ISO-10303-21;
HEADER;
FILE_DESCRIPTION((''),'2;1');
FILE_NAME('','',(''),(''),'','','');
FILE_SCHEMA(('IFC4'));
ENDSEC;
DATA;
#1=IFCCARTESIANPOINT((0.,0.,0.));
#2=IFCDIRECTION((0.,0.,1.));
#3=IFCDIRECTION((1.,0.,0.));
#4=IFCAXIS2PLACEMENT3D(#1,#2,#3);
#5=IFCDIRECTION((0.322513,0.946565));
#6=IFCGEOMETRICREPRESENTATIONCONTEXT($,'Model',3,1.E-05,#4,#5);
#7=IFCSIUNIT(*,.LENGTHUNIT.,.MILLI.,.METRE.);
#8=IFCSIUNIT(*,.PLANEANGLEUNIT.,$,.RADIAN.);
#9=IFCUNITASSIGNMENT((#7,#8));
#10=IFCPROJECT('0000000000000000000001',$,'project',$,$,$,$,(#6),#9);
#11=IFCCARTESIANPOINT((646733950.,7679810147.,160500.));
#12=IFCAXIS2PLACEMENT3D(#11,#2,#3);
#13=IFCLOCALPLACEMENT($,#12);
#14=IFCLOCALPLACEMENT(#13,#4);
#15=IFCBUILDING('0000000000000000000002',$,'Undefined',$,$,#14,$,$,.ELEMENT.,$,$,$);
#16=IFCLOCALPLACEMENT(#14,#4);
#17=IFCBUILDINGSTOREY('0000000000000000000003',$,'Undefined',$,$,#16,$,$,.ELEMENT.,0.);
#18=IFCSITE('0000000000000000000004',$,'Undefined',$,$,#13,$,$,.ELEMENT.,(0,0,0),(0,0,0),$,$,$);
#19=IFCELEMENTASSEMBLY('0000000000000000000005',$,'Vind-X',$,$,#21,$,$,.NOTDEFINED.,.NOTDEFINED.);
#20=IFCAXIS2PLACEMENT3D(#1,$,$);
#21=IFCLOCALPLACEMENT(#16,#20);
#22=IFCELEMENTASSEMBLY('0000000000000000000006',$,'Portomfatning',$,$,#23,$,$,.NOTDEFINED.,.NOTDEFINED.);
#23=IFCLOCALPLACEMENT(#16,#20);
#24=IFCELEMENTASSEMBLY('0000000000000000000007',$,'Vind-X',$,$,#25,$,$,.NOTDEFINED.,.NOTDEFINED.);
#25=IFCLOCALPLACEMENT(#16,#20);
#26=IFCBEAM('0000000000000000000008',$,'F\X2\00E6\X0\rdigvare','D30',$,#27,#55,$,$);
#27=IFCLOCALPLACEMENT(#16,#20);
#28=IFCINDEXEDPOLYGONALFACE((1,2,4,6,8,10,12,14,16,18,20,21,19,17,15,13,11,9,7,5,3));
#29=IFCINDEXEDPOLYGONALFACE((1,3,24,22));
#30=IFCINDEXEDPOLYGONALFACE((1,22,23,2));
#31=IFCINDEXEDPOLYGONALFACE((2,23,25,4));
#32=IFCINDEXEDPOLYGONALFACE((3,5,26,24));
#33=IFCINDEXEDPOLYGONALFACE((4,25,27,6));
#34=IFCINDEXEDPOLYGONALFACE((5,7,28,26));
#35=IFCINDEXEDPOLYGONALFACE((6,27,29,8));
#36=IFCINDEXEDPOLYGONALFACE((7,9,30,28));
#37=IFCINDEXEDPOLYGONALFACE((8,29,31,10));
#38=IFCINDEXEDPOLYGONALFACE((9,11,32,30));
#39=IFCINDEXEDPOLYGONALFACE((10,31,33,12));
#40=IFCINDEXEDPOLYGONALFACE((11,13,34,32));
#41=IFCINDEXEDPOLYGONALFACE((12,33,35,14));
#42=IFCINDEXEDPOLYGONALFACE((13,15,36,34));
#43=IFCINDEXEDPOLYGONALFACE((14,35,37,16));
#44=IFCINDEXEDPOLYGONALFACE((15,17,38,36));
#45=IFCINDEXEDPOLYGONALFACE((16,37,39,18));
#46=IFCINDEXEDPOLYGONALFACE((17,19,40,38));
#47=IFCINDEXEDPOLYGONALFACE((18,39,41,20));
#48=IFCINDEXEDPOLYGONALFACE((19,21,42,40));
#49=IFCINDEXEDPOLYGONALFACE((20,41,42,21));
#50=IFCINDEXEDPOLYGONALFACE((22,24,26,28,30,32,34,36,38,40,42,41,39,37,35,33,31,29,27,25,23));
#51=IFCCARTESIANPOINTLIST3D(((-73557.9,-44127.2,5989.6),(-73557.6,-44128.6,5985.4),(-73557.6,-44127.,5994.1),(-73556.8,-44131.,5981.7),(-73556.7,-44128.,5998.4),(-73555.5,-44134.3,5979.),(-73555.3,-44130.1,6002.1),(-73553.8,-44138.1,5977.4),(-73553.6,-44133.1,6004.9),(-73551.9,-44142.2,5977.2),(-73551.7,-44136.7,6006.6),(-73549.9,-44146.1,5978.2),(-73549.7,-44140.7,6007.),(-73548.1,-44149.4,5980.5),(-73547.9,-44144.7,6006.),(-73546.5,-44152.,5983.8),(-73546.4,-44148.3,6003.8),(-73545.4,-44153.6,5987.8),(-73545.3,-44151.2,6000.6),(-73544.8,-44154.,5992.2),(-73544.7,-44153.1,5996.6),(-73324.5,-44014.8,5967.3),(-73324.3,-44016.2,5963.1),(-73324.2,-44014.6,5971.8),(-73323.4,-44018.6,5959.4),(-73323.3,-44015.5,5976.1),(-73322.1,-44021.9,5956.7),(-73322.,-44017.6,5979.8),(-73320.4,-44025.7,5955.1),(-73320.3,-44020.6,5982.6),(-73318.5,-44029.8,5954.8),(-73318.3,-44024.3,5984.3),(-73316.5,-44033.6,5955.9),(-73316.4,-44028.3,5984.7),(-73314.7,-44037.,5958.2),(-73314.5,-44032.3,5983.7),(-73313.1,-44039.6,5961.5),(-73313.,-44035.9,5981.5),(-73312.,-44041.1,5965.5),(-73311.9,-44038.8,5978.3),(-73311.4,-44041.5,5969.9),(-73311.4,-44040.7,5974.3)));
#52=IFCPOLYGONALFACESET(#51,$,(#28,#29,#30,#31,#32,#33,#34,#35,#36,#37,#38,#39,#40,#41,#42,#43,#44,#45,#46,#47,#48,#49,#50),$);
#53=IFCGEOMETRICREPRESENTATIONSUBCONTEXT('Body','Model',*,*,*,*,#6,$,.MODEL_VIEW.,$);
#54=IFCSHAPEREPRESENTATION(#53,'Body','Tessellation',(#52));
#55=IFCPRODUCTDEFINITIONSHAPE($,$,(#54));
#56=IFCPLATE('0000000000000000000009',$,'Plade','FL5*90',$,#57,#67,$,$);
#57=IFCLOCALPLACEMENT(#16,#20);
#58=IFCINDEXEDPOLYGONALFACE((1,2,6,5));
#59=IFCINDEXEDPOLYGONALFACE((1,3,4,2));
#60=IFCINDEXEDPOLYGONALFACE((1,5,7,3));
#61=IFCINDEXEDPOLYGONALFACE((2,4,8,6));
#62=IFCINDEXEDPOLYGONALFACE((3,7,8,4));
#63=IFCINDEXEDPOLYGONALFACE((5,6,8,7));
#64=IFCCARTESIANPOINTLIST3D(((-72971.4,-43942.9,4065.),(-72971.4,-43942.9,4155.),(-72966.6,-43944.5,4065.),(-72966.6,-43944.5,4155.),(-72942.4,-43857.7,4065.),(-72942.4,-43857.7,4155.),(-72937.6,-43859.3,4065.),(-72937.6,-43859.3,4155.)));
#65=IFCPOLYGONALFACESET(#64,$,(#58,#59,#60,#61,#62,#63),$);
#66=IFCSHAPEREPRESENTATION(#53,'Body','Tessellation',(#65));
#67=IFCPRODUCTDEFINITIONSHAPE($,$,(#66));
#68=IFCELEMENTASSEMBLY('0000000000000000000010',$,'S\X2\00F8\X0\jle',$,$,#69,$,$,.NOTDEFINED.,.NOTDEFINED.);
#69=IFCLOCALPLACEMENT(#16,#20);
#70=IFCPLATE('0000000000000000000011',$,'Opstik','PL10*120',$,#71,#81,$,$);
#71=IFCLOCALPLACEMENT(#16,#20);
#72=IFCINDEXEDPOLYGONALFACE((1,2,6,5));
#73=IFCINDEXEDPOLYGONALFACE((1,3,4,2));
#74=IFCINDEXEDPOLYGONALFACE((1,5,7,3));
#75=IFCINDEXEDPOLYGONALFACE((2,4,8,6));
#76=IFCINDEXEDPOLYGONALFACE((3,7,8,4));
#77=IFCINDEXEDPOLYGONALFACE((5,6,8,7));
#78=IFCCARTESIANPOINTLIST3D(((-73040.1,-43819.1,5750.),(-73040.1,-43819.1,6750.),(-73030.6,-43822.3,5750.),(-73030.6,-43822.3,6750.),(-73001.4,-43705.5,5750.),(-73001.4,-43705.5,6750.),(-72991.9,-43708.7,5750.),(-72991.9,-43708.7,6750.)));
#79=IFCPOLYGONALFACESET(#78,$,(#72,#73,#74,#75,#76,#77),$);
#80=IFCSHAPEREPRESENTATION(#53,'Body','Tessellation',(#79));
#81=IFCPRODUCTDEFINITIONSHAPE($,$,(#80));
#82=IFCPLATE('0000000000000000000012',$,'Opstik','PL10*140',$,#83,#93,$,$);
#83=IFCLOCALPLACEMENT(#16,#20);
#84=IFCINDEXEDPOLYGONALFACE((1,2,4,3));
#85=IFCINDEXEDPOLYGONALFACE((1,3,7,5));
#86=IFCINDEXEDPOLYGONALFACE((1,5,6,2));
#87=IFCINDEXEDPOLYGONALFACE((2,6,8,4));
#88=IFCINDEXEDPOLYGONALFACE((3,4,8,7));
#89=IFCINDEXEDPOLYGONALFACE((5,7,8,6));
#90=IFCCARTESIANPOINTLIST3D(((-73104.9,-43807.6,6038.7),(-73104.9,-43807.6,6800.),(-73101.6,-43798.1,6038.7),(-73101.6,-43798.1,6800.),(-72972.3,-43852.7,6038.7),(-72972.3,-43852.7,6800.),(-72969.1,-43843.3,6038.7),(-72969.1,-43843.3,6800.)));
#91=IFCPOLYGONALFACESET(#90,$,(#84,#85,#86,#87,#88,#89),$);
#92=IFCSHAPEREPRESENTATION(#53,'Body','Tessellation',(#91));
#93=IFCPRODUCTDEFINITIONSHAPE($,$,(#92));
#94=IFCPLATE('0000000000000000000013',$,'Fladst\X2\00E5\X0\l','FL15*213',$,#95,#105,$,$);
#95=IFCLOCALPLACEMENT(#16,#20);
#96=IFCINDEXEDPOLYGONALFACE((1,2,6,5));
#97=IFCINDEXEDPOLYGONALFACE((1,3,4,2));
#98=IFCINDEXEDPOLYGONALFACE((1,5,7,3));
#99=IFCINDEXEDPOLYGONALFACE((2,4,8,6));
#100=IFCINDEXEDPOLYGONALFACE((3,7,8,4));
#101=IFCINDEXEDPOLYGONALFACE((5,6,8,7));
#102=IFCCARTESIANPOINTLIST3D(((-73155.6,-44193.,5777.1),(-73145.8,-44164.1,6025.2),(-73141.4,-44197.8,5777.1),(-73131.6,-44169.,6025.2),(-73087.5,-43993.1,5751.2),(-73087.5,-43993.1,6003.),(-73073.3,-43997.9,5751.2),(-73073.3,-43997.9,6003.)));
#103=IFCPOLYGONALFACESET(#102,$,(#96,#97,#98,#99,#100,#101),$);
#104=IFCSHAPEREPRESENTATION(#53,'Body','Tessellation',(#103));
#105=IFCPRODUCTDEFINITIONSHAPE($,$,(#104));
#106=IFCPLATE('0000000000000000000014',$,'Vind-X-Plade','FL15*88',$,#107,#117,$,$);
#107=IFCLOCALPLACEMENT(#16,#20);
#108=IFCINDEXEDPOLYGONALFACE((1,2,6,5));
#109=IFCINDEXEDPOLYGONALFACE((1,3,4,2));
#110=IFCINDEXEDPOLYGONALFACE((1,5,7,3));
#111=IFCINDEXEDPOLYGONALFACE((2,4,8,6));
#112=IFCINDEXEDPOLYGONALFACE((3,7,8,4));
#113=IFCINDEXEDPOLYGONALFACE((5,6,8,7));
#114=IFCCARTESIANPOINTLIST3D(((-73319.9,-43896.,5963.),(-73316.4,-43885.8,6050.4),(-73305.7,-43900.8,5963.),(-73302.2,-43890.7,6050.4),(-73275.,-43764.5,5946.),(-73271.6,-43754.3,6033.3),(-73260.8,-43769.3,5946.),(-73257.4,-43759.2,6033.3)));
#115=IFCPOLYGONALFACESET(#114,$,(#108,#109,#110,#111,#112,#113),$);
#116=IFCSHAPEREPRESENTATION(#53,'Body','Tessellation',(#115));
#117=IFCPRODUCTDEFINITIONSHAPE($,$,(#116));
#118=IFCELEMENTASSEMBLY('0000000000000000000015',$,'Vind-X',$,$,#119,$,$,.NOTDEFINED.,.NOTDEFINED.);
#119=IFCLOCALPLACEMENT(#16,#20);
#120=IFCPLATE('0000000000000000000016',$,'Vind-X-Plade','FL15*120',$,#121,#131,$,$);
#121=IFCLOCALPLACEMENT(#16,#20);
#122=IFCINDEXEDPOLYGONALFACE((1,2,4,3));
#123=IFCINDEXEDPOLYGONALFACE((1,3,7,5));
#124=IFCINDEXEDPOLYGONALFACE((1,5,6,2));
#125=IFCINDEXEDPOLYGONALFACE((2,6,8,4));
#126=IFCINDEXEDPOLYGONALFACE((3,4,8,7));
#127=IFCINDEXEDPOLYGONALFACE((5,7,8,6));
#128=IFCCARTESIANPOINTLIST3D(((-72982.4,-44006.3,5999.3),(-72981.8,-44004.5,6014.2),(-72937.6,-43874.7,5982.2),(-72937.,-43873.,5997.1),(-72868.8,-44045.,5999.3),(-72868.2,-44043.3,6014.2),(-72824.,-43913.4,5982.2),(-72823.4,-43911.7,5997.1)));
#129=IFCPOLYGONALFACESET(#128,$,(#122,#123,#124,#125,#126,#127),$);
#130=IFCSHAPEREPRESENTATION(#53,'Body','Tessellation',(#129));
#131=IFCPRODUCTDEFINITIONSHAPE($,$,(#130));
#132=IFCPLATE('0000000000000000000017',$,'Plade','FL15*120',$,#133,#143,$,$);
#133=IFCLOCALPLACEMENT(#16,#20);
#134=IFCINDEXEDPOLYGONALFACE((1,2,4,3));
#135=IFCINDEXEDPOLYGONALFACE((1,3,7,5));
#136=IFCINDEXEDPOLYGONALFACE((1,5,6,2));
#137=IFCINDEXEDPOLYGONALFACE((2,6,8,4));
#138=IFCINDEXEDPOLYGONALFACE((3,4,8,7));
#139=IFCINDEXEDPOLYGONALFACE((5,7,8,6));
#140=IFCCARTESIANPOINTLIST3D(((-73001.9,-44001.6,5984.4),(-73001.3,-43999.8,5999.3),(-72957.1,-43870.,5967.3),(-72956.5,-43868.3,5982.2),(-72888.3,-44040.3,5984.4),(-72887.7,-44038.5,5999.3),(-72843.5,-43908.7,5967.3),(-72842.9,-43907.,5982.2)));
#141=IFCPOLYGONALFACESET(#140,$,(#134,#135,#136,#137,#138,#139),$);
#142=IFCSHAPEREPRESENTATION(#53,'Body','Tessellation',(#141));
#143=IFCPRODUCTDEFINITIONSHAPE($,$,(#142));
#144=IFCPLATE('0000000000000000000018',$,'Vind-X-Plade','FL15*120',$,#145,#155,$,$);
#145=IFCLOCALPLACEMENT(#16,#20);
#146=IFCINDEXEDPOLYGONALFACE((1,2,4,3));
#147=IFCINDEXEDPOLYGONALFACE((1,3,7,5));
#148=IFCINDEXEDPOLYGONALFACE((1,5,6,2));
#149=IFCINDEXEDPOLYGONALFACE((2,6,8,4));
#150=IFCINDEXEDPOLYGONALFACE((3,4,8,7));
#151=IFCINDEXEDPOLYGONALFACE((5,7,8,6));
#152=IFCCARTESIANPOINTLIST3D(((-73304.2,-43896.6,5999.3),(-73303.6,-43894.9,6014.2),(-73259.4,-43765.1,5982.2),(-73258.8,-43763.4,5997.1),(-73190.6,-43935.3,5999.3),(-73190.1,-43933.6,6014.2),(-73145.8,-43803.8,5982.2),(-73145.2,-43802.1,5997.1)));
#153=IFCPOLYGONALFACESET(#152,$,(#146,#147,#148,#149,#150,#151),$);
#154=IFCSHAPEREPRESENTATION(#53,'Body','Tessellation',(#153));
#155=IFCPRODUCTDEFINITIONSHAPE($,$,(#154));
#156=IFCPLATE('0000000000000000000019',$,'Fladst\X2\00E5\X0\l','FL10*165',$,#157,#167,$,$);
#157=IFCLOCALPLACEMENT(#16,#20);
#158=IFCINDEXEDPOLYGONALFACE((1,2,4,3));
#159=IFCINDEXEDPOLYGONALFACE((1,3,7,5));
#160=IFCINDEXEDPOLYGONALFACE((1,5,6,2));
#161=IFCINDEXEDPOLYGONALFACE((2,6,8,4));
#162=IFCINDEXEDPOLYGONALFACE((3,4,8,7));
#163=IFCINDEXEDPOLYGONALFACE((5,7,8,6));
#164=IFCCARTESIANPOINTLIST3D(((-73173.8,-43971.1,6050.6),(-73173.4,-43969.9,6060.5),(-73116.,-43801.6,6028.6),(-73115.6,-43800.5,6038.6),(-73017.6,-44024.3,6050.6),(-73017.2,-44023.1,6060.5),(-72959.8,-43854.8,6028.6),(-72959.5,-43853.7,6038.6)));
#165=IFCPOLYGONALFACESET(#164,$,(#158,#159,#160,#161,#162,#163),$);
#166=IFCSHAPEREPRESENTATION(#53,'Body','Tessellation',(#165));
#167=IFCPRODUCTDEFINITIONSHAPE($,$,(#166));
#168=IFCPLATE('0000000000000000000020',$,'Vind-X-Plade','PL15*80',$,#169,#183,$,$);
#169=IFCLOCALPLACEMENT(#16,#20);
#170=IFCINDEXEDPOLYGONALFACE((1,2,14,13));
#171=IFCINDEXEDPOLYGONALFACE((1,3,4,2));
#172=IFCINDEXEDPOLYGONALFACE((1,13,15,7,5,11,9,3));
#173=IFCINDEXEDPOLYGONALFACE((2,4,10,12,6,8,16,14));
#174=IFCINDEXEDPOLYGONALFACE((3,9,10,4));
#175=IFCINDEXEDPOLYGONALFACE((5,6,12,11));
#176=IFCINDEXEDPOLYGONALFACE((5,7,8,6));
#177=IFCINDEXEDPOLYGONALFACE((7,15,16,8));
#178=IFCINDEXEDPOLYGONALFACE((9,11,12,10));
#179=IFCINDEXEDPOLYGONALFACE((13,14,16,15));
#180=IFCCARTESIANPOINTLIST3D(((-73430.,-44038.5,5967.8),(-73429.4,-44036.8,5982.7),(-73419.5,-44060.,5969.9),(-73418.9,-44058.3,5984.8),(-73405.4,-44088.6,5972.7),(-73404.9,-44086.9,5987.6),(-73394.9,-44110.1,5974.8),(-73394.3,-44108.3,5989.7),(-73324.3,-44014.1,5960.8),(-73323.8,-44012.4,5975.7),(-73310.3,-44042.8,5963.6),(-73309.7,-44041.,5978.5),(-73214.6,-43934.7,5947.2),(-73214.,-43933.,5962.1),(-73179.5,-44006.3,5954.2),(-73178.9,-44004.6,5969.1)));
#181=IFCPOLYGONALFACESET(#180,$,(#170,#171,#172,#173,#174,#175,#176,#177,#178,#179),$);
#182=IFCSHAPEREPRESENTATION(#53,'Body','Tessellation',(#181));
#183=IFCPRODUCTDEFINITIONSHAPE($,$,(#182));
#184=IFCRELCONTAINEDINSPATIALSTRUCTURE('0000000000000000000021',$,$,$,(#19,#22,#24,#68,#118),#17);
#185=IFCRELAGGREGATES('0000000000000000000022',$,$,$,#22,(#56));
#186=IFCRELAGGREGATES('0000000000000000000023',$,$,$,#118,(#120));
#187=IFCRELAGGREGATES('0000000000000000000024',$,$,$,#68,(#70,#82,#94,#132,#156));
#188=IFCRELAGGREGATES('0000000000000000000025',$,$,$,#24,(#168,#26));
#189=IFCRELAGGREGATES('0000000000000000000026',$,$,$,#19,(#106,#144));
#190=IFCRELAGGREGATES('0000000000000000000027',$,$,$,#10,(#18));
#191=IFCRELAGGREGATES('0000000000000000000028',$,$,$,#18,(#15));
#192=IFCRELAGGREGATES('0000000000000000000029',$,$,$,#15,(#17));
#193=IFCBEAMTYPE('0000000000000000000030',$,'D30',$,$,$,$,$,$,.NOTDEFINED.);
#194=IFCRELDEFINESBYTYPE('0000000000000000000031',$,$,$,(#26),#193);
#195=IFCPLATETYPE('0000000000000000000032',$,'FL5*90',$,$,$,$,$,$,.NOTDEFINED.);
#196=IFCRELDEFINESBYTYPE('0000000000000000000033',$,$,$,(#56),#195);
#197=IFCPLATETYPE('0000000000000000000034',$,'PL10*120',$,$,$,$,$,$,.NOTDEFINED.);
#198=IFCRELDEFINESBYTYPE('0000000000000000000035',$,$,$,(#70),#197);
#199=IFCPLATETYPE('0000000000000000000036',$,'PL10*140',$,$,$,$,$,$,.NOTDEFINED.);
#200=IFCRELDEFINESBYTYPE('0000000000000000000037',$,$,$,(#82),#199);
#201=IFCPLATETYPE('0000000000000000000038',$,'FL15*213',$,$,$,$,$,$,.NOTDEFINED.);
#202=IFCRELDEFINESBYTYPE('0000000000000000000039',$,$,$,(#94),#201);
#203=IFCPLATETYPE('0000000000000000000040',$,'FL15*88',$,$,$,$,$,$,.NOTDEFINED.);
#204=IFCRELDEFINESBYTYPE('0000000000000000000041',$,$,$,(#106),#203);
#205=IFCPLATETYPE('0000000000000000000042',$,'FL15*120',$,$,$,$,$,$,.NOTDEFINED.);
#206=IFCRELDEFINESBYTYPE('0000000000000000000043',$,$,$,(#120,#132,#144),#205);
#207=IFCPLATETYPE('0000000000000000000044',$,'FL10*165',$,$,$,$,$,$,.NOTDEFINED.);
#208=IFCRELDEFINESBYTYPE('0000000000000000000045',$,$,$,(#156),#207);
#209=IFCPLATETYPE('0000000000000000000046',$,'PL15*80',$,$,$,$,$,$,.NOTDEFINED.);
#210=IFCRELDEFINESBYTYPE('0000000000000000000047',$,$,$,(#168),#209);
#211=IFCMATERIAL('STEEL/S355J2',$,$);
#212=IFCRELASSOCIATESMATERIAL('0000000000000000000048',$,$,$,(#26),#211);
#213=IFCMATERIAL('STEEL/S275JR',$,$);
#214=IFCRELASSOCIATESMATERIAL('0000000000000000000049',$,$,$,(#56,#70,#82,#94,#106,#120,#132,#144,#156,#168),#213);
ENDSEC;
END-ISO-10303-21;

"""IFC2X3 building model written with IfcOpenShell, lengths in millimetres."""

from ifc_helpers import new_model, si_unit, direction, frame, origin_with_axes, origin_2d_with_axis, place, context, subcontext, project, spatial, polyline, circle, outline, extrude, boolean, material, type_object, element, aggregate, save


model = new_model("IFC2X3")

# Units and contexts
model_context = context("Model", 3, precision=1e-05, world=origin_with_axes(), true_north=direction((0.322513, 0.946565)))
body_context = subcontext(model_context, "Body", "Model", "MODEL_VIEW")
ifc_project = project(units=[si_unit("LENGTHUNIT", "METRE", prefix="MILLI"), si_unit("PLANEANGLEUNIT", "RADIAN")], contexts=[model_context])

# Site, building, storey
site_placement = place(None, frame((646733950.0, 7679810147.0, 160500.0), z_axis=(0.0, 0.0, 1.0), x_axis=(1.0, 0.0, 0.0)))
site = spatial("IfcSite", under=ifc_project, at=site_placement, Name="Undefined", CompositionType="ELEMENT", RefLatitude=(0, 0, 0), RefLongitude=(0, 0, 0))
building_placement = place(site_placement, origin_with_axes())
building = spatial("IfcBuilding", under=site, at=building_placement, Name="Undefined", CompositionType="ELEMENT")
storey_placement = place(building_placement, origin_with_axes())
storey = spatial("IfcBuildingStorey", under=building, at=storey_placement, Name="Undefined", CompositionType="ELEMENT", Elevation=0.0)

# Element assemblies
assembly_1_placement = place(storey_placement, origin_with_axes())
assembly_1 = element("IfcElementAssembly", 1, at=assembly_1_placement, inside=storey, Name="Vind-X", AssemblyPlace="NOTDEFINED", PredefinedType="NOTDEFINED")
assembly_2_placement = place(storey_placement, origin_with_axes())
assembly_2 = element("IfcElementAssembly", 2, at=assembly_2_placement, inside=storey, Name="Portomfatning", AssemblyPlace="NOTDEFINED", PredefinedType="NOTDEFINED")

# Element assembly, beam
assembly_3_placement = place(storey_placement, origin_with_axes())
assembly_3 = element("IfcElementAssembly", 3, at=assembly_3_placement, inside=storey, Name="Vind-X", AssemblyPlace="NOTDEFINED", PredefinedType="NOTDEFINED")
ifc_material_1 = material(Name="STEEL/S355J2")
beam_type_1 = type_object("IfcBeamType", Name="D30", PredefinedType="NOTDEFINED")
beam_1_placement = place(assembly_3_placement, frame((-73317.9, -44028.0, 5969.7), z_axis=(-0.439079, 0.89427, -0.086548), x_axis=(-0.897588, -0.432405, 0.0858)))
beam_1 = element("IfcBeam", 4, at=beam_1_placement, type_object=beam_type_1, material=ifc_material_1, Name="Færdigvare", Description="D30", context=body_context, shape_type="SweptSolid", body=[
    extrude(circle(Radius=15.0, at=origin_2d_with_axis()), frame((260.0, 0.0, 0.0), z_axis=(-1.0, 0.0, 0.0), x_axis=(0.0, -1.0, 0.0)), (0.0, 0.0, 1.0), 260.0),
])

# Plate
ifc_material_2 = material(Name="STEEL/S275JR")
plate_type_1 = type_object("IfcPlateType", Name="FL5*90", PredefinedType="NOTDEFINED")
plate_1_placement = place(assembly_2_placement, frame((-72940.0, -43858.5, 4155.0), z_axis=(-0.946625, 0.322338, 0.0), x_axis=(0.0, 0.0, -1.0)))
plate_1 = element("IfcPlate", 5, at=plate_1_placement, type_object=plate_type_1, material=ifc_material_2, Name="Plade", Description="FL5*90", context=body_context, shape_type="SweptSolid", body=[
    extrude(outline(polyline([(0.0, 0.0), (90.0, 0.0), (90.0, 90.0), (0.0, 90.0), (0.0, 0.0)])), frame((0.0, 0.0, -2.5), z_axis=(0.0, 0.0, 1.0), x_axis=(1.0, 0.0, 0.0)), (0.0, 0.0, 1.0), 5.0),
])
aggregate(assembly_2, [plate_1])

# Element assembly, plates
assembly_4_placement = place(storey_placement, origin_with_axes())
assembly_4 = element("IfcElementAssembly", 6, at=assembly_4_placement, inside=storey, Name="Søjle", AssemblyPlace="NOTDEFINED", PredefinedType="NOTDEFINED")
plate_type_2 = type_object("IfcPlateType", Name="PL10*120", PredefinedType="NOTDEFINED")
plate_2_placement = place(assembly_4_placement, frame((-73035.4, -43820.7, 5750.0), z_axis=(-0.946565, 0.322513, 0.0), x_axis=(0.0, 0.0, 1.0)))
plate_2 = element("IfcPlate", 7, at=plate_2_placement, type_object=plate_type_2, material=ifc_material_2, Name="Opstik", Description="PL10*120", context=body_context, shape_type="SweptSolid", body=[
    extrude(outline(polyline([(0.0, 0.0), (1000.0, 0.0), (1000.0, 120.0), (1000.0, 120.0), (0.0, 120.0), (0.0, 120.0), (0.0, 0.0)])), frame((0.0, 0.0, -5.0), z_axis=(0.0, 0.0, 1.0), x_axis=(1.0, 0.0, 0.0)), (0.0, 0.0, 1.0), 10.0),
])
plate_type_3 = type_object("IfcPlateType", Name="PL10*140", PredefinedType="NOTDEFINED")
plate_3_placement = place(assembly_4_placement, frame((-73103.3, -43802.9, 6038.7), z_axis=(0.322513, 0.946565, 0.0), x_axis=(0.0, 0.0, 1.0)))
plate_3 = element("IfcPlate", 8, at=plate_3_placement, type_object=plate_type_3, material=ifc_material_2, Name="Opstik", Description="PL10*140", context=body_context, shape_type="SweptSolid", body=[
    extrude(outline(polyline([(0.0, 0.0), (761.3, 0.0), (761.3, 0.0), (761.3, 140.0), (761.3, 140.0), (0.0, 140.0), (0.0, 0.0)])), frame((0.0, 0.0, -5.0), z_axis=(0.0, 0.0, 1.0), x_axis=(1.0, 0.0, 0.0)), (0.0, 0.0, 1.0), 10.0),
])
plate_type_4 = type_object("IfcPlateType", Name="FL15*213", PredefinedType="NOTDEFINED")
plate_4_placement = place(assembly_4_placement, frame((-73080.4, -43995.5, 6003.0), z_axis=(-0.946565, 0.322513, 0.0), x_axis=(0.0, 0.0, -1.0)))
plate_4 = element("IfcPlate", 9, at=plate_4_placement, type_object=plate_type_4, material=ifc_material_2, Name="Fladstål", Description="FL15*213", context=body_context, shape_type="SweptSolid", body=[
    extrude(outline(polyline([(0.0, 0.0), (251.9, 0.0), (226.0, 211.1), (-22.2, 180.7), (0.0, 0.0)])), frame((0.0, 0.0, -7.5), z_axis=(0.0, 0.0, 1.0), x_axis=(1.0, 0.0, 0.0)), (0.0, 0.0, 1.0), 15.0),
])

# Plate
plate_type_5 = type_object("IfcPlateType", Name="FL15*88", PredefinedType="NOTDEFINED")
plate_5_placement = place(assembly_1_placement, frame((-73264.5, -43756.7, 6033.3), z_axis=(0.946565, -0.322513, 0.0), x_axis=(-0.320109, -0.93951, 0.121869)))
plate_5 = element("IfcPlate", 10, at=plate_5_placement, type_object=plate_type_5, material=ifc_material_2, Name="Vind-X-Plade", Description="FL15*88", context=body_context, shape_type="SweptSolid", body=[
    extrude(outline(polyline([(0.0, 0.0), (140.0, 0.0), (140.0, 88.0), (0.0, 88.0), (0.0, 0.0)])), frame((0.0, 0.0, -7.5), z_axis=(0.0, 0.0, 1.0), x_axis=(1.0, 0.0, 0.0)), (0.0, 0.0, 1.0), 15.0),
])

# Element assembly, plate
assembly_5_placement = place(storey_placement, origin_with_axes())
assembly_5 = element("IfcElementAssembly", 11, at=assembly_5_placement, inside=storey, Name="Vind-X", AssemblyPlace="NOTDEFINED", PredefinedType="NOTDEFINED")
plate_type_6 = type_object("IfcPlateType", Name="FL15*120", PredefinedType="NOTDEFINED")
plate_6_placement = place(assembly_5_placement, frame((-72959.7, -43939.6, 5998.2), z_axis=(-0.039304, -0.115357, -0.992546), x_axis=(0.946565, -0.322513, 0.0)))
plate_6 = element("IfcPlate", 12, at=plate_6_placement, type_object=plate_type_6, material=ifc_material_2, Name="Vind-X-Plade", Description="FL15*120", context=body_context, shape_type="SweptSolid", body=[
    extrude(outline(polyline([(0.0, -70.0), (0.0, 70.0), (120.0, 70.0), (120.0, -70.0), (0.0, -70.0)])), frame((0.0, 0.0, -7.5), z_axis=(0.0, 0.0, 1.0), x_axis=(1.0, 0.0, 0.0)), (0.0, 0.0, 1.0), 15.0),
])
aggregate(assembly_5, [plate_6])

# Plates
plate_7_placement = place(assembly_4_placement, frame((-72956.8, -43869.2, 5974.8), z_axis=(0.039304, 0.115357, 0.992546), x_axis=(-0.320109, -0.93951, 0.121869)))
plate_7 = element("IfcPlate", 13, at=plate_7_placement, type_object=plate_type_6, material=ifc_material_2, Name="Plade", Description="FL15*120", context=body_context, shape_type="SweptSolid", body=[
    extrude(outline(polyline([(0.0, 0.0), (140.0, 0.0), (140.0, 120.0), (0.0, 120.0), (0.0, 0.0)])), frame((0.0, 0.0, -7.5), z_axis=(0.0, 0.0, 1.0), x_axis=(1.0, 0.0, 0.0)), (0.0, 0.0, 1.0), 15.0),
])
plate_8_placement = place(assembly_1_placement, frame((-73167.9, -43868.7, 5998.2), z_axis=(0.039304, 0.115357, 0.992546), x_axis=(-0.946565, 0.322513, 0.0)))
plate_8 = element("IfcPlate", 14, at=plate_8_placement, type_object=plate_type_6, material=ifc_material_2, Name="Vind-X-Plade", Description="FL15*120", context=body_context, shape_type="SweptSolid", body=[
    extrude(outline(polyline([(0.0, -70.0), (0.0, 70.0), (120.0, 70.0), (120.0, -70.0), (0.0, -70.0)])), frame((0.0, 0.0, -7.5), z_axis=(0.0, 0.0, 1.0), x_axis=(1.0, 0.0, 0.0)), (0.0, 0.0, 1.0), 15.0),
])
plate_type_7 = type_object("IfcPlateType", Name="FL10*165", PredefinedType="NOTDEFINED")
plate_9_placement = place(assembly_4_placement, frame((-73095.5, -43997.1, 6055.6), z_axis=(-0.039304, -0.115357, -0.992546), x_axis=(0.320109, 0.93951, -0.121869)))
plate_9 = element("IfcPlate", 15, at=plate_9_placement, type_object=plate_type_7, material=ifc_material_2, Name="Fladstål", Description="FL10*165", context=body_context, shape_type="SweptSolid", body=[
    extrude(outline(polyline([(0.0, -82.5), (0.0, 82.5), (180.4, 82.5), (180.4, -82.5), (0.0, -82.5)])), frame((0.0, 0.0, -5.0), z_axis=(0.0, 0.0, 1.0), x_axis=(1.0, 0.0, 0.0)), (0.0, 0.0, 1.0), 10.0),
])
plate_type_8 = type_object("IfcPlateType", Name="PL15*80", PredefinedType="NOTDEFINED")
plate_10_placement = place(assembly_3_placement, frame((-73179.2, -44005.4, 5961.6), z_axis=(0.039304, 0.115357, 0.992546), x_axis=(-0.439079, 0.89427, -0.086548)))
plate_10 = element("IfcPlate", 16, at=plate_10_placement, type_object=plate_type_8, material=ifc_material_2, Name="Vind-X-Plade", Description="PL15*80", context=body_context, shape_type="CSG", body=[
    boolean("DIFFERENCE", extrude(outline(polyline([(0.0, 0.0), (80.0, 0.0), (80.0, 240.0), (0.0, 240.0), (0.0, 0.0)])), frame((0.0, 0.0, -7.5), z_axis=(0.0, 0.0, 1.0), x_axis=(1.0, 0.0, 0.0)), (0.0, 0.0, 1.0), 15.0), extrude(outline(polyline([(0.0, 0.0), (106.0, 0.0), (106.0, 32.0), (0.0, 32.0), (0.0, 0.0)])), frame((56.0, 240.0, 8.5), z_axis=(0.0, 0.0, -1.0), x_axis=(0.0, -1.0, 0.0)), (0.0, 0.0, 1.0), 17.0)),
])

aggregate(assembly_4, [plate_2, plate_3, plate_4, plate_7, plate_9])

aggregate(assembly_3, [plate_10, beam_1])

aggregate(assembly_1, [plate_5, plate_8])

save(model, "model.ifc")
